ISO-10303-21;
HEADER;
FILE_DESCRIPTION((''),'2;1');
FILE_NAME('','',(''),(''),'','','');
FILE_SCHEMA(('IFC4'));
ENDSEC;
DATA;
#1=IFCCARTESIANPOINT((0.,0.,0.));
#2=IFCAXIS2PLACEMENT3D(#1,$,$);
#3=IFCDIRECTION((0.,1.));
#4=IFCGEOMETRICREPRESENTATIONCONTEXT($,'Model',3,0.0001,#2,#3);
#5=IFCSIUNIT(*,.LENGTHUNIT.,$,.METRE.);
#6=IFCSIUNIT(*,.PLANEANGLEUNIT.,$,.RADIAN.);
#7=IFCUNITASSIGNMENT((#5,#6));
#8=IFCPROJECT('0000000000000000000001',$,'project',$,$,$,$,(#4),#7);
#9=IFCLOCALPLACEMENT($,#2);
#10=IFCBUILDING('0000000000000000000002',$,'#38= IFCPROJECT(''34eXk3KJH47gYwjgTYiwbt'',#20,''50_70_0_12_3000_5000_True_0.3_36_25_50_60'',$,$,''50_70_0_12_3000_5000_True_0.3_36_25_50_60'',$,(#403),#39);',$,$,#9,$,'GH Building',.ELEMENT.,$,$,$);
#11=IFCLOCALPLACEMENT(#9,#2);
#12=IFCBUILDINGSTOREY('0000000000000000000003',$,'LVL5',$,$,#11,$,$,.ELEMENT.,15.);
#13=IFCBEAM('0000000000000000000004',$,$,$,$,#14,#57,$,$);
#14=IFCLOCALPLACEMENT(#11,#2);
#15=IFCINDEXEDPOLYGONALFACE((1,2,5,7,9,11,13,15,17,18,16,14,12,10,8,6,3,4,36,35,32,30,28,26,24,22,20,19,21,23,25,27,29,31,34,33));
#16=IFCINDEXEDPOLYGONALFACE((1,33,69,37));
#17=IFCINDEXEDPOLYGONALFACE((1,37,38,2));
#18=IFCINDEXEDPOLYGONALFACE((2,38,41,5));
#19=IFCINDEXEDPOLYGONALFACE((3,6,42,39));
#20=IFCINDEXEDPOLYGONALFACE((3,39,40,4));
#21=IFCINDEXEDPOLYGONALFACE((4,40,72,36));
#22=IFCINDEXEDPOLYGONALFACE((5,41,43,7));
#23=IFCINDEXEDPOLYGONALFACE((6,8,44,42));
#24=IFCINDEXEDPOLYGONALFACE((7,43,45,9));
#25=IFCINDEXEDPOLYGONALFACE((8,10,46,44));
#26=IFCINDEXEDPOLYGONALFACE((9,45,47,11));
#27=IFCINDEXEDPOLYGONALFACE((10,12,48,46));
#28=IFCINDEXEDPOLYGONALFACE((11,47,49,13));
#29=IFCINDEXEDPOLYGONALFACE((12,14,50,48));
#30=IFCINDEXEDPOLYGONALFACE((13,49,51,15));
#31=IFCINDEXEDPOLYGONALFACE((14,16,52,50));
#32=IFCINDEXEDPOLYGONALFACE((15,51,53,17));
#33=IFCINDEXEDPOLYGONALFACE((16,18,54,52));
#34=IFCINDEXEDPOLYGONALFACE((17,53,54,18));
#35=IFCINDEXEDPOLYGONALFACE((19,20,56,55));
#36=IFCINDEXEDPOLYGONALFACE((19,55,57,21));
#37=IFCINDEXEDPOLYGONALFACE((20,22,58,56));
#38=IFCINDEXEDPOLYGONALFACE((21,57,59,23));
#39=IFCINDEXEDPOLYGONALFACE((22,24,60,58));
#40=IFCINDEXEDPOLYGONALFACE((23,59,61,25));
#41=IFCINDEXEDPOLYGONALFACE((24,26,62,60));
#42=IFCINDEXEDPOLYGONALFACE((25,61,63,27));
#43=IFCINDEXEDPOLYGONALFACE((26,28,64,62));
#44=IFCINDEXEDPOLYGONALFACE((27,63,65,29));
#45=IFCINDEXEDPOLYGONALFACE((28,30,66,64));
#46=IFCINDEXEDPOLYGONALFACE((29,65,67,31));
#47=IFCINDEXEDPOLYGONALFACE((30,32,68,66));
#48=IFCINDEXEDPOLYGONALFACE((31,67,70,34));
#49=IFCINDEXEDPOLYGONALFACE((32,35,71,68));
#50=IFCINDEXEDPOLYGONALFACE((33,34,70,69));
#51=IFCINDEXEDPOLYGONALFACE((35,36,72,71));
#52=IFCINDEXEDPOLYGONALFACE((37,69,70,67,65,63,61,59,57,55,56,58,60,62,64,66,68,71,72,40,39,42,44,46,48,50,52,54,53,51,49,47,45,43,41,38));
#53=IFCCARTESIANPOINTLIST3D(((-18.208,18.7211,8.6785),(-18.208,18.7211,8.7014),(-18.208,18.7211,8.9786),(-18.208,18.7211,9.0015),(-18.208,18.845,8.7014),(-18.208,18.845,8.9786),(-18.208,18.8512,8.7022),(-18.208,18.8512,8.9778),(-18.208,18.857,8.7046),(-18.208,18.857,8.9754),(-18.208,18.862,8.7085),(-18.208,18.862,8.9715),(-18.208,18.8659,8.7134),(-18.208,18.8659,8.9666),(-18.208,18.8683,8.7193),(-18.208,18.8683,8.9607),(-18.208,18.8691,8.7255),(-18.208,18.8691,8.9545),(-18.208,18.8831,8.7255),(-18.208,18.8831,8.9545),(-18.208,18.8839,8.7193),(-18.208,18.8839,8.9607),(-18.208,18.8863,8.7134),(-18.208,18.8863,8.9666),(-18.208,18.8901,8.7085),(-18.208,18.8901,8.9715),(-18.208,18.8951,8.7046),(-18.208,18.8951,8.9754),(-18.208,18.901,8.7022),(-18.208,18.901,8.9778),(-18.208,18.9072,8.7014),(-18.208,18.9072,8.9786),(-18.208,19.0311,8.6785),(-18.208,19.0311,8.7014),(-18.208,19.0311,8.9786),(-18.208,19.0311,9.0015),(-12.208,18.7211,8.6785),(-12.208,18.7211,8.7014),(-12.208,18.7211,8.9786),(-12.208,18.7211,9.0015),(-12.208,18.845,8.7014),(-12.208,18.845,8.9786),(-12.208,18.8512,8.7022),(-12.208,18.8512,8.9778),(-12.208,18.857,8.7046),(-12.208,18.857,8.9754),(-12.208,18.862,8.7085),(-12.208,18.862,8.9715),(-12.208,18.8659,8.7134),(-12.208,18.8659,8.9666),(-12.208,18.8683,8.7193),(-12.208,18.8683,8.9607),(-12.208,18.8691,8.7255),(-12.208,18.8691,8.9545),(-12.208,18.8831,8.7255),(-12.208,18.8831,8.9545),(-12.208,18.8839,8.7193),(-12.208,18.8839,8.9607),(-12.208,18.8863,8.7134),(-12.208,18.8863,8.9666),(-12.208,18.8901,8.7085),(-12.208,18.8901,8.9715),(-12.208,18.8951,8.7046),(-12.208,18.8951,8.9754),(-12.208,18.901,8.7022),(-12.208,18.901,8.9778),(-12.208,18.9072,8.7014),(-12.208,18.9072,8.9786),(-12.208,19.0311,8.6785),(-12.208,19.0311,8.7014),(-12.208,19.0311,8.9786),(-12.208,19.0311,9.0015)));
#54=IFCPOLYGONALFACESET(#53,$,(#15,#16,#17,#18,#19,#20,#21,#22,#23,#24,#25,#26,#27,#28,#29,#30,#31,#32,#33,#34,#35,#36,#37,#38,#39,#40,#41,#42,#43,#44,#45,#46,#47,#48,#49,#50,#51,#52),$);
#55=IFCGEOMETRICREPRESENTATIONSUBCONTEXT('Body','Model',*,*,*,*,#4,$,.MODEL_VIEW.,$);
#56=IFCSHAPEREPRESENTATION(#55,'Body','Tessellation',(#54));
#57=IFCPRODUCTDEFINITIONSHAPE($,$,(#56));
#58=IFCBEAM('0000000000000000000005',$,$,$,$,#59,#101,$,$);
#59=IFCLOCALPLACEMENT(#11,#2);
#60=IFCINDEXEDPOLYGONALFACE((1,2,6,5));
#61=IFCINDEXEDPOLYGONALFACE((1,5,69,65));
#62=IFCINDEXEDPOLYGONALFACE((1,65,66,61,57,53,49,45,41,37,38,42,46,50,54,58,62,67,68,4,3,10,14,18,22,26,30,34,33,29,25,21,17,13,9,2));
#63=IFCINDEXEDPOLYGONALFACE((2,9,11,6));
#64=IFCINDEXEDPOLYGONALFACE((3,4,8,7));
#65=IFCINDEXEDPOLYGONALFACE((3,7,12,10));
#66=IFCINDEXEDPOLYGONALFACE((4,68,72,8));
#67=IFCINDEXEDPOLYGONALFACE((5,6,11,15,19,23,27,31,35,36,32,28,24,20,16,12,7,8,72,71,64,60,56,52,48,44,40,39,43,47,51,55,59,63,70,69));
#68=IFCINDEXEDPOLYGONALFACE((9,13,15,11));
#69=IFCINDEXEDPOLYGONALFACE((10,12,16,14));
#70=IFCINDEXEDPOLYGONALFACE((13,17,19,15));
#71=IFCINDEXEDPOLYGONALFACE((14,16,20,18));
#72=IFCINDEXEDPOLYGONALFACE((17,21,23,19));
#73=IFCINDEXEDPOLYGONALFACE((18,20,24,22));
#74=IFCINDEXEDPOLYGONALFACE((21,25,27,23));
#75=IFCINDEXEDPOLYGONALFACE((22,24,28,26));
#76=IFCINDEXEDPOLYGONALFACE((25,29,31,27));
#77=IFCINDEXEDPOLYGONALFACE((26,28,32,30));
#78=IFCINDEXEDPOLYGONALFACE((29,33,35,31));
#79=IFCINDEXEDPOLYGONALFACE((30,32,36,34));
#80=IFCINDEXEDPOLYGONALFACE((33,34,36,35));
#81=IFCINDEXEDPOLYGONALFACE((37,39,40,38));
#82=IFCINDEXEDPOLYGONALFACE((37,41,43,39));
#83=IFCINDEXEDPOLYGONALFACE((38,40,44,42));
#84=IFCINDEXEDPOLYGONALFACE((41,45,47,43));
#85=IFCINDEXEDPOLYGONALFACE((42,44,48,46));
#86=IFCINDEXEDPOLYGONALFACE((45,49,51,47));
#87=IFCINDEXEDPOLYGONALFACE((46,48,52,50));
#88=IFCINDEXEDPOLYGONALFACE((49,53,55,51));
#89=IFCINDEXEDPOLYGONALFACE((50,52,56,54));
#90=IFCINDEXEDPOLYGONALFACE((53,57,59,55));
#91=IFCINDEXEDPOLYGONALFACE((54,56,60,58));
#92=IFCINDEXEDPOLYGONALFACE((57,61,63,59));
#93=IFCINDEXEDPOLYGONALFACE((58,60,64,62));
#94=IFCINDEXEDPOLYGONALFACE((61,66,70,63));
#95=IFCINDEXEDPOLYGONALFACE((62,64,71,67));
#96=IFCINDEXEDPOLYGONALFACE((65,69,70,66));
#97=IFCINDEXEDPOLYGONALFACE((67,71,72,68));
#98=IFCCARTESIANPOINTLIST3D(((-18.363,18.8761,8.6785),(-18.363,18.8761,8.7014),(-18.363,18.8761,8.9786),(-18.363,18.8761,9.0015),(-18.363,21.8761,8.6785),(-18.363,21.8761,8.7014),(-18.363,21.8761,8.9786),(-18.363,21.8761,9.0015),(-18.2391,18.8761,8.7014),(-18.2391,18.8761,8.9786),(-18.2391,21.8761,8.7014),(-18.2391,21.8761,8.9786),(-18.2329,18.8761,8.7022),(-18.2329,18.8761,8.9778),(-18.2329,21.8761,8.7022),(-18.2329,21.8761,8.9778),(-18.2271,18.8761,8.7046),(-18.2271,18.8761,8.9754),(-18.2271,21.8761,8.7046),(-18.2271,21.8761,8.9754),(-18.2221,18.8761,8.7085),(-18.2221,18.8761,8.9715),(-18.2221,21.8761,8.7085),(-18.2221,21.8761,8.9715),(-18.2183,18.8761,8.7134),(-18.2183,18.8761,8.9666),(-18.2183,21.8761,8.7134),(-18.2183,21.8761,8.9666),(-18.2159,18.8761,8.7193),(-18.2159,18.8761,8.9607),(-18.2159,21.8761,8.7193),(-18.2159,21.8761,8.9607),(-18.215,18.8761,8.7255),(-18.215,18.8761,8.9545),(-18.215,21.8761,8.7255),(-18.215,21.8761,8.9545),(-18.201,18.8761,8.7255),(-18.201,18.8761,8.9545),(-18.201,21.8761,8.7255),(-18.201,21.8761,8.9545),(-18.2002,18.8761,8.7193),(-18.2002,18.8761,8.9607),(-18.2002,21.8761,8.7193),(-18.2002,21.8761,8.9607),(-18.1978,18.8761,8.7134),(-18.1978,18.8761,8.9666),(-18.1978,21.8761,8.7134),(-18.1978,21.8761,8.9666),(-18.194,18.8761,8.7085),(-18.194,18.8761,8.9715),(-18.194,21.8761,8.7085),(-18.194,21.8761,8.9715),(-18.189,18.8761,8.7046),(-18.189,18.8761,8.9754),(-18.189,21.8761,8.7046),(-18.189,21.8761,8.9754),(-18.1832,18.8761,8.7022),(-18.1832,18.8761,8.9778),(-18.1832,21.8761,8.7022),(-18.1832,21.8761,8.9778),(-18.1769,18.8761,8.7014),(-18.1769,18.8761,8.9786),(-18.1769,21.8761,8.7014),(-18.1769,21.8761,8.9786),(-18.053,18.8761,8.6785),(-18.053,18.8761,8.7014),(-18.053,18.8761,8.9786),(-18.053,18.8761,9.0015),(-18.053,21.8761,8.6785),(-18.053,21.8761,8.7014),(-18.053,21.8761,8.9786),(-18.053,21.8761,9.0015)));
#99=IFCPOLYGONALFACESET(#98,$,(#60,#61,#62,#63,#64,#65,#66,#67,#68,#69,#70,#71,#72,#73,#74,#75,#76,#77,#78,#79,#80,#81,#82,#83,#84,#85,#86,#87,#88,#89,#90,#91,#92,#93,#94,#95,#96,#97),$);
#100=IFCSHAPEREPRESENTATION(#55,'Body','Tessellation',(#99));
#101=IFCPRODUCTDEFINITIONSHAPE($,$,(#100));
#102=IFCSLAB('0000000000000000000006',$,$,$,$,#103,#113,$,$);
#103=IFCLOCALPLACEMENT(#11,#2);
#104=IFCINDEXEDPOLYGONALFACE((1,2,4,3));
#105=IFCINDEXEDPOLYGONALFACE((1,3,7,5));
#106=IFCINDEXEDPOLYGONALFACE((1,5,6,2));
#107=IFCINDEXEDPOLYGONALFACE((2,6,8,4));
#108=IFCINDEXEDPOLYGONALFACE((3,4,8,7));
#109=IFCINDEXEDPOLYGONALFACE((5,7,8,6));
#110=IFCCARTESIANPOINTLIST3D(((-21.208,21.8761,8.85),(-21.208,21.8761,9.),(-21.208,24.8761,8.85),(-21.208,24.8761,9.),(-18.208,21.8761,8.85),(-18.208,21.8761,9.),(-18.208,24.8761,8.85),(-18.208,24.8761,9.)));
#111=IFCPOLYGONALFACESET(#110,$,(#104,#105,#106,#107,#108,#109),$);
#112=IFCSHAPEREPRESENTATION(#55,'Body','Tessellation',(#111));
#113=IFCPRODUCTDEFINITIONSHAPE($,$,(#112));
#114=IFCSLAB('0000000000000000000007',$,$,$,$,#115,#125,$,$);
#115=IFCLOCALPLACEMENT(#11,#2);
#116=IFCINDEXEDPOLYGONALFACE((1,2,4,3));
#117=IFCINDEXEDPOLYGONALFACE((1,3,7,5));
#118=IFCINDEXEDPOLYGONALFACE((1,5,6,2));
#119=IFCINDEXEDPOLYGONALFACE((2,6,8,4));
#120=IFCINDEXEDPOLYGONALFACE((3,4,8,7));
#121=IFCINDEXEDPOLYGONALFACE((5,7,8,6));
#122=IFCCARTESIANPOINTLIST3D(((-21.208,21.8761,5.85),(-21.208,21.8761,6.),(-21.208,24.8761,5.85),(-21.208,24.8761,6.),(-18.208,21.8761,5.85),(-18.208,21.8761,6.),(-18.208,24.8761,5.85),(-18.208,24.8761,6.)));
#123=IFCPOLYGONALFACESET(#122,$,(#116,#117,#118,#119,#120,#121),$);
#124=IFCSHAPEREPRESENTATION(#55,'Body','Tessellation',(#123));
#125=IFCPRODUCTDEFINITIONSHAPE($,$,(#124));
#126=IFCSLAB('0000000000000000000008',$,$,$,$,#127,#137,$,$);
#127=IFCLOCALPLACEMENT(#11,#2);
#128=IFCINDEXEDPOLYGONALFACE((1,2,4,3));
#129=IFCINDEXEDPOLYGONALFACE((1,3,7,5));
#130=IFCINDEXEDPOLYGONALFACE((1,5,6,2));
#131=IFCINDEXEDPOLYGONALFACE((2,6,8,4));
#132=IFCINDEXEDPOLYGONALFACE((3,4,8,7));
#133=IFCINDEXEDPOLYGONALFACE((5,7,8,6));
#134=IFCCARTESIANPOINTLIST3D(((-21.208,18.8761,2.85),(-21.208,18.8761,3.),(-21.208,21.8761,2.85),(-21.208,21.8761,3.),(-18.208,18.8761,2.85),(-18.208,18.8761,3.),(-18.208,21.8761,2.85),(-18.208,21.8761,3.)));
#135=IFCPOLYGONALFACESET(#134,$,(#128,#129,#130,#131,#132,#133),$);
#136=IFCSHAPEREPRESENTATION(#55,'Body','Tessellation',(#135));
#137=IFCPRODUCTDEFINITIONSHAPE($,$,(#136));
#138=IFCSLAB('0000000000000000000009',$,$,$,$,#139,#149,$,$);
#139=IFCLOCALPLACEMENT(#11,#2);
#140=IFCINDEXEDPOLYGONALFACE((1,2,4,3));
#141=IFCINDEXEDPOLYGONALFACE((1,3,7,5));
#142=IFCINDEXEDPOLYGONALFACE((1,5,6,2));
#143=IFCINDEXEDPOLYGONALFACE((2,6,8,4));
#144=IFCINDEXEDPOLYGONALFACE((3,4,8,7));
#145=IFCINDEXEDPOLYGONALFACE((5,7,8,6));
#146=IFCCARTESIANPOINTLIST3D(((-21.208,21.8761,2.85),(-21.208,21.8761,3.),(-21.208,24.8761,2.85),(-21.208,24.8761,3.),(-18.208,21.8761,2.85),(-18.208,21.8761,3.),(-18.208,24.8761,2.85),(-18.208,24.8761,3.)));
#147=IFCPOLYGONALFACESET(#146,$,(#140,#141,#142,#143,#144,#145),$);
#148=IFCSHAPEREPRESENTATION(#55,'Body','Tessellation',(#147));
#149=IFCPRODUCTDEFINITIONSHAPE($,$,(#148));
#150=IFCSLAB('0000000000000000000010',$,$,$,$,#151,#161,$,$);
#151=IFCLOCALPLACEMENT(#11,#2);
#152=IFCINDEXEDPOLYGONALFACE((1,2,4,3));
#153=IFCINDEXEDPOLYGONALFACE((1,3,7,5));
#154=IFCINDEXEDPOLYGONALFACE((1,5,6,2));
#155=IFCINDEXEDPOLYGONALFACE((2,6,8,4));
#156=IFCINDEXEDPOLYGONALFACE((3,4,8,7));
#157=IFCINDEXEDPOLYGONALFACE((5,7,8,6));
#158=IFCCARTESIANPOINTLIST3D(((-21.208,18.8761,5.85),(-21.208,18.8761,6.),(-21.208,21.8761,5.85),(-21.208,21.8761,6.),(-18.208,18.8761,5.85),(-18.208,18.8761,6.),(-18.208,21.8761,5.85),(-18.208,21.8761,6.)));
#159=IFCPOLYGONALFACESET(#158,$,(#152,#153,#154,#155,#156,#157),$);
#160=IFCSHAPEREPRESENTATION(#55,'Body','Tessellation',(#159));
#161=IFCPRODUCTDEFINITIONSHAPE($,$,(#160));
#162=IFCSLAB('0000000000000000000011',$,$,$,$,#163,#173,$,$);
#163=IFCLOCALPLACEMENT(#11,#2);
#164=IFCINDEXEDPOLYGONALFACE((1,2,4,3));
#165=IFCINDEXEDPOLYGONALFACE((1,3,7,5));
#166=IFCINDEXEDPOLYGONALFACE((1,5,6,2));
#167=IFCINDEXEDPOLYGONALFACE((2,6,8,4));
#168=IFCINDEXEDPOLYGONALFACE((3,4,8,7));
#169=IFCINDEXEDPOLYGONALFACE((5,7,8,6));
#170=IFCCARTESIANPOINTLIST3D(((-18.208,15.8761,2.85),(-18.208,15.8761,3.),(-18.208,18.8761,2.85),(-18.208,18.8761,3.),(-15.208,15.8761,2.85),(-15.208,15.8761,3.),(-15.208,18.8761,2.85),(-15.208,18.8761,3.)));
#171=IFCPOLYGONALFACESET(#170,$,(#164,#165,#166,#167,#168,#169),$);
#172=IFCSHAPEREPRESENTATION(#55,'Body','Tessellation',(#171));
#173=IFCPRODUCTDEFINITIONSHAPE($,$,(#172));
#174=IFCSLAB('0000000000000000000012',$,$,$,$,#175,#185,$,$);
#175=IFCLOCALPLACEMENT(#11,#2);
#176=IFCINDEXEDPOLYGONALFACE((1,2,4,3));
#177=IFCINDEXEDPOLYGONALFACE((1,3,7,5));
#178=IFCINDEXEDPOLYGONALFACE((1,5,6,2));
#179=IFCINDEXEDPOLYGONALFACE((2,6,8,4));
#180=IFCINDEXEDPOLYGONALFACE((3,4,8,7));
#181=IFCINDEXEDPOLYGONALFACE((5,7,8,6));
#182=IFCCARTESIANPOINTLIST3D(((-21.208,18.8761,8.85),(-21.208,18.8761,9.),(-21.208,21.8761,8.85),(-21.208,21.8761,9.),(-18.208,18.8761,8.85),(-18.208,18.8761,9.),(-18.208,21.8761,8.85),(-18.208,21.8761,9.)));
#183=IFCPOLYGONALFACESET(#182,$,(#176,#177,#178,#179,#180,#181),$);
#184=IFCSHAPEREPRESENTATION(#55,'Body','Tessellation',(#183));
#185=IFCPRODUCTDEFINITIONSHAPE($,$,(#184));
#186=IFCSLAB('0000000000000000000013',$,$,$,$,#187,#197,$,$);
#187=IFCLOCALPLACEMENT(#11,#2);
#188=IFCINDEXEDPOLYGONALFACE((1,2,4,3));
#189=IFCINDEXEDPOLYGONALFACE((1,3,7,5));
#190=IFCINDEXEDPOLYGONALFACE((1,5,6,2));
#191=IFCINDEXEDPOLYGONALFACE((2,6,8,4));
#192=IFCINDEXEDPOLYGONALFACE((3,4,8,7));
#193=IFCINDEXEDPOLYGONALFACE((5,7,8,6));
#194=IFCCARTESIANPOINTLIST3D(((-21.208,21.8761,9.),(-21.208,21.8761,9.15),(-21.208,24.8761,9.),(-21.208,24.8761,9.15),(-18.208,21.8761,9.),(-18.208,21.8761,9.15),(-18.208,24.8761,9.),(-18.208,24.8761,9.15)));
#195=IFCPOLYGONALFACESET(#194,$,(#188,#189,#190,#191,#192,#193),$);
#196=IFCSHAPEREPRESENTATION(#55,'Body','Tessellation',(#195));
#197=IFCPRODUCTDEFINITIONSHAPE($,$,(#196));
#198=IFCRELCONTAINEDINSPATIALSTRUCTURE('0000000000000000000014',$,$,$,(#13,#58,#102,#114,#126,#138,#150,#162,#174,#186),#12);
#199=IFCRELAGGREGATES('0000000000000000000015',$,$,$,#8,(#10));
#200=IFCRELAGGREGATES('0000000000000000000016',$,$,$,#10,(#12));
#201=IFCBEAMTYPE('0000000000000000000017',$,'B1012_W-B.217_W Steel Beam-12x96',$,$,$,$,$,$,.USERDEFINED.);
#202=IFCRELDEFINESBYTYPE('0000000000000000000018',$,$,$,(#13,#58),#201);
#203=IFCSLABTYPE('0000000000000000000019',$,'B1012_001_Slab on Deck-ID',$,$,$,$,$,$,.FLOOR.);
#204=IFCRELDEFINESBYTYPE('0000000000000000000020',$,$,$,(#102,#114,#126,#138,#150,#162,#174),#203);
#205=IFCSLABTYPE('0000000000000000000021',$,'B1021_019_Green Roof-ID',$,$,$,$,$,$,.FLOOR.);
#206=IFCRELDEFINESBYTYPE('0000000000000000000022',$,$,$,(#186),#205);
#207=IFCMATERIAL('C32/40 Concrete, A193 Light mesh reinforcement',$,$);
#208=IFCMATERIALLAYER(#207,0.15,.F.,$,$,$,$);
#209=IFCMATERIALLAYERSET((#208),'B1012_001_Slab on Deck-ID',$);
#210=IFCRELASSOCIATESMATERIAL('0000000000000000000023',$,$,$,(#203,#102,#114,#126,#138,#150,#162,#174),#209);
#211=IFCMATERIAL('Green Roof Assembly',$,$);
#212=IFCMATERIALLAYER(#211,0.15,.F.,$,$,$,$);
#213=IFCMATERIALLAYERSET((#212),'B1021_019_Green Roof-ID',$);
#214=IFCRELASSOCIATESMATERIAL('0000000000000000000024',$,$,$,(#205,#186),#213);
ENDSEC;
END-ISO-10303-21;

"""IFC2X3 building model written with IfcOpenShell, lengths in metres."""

from ifc_helpers import new_model, si_unit, direction, frame, origin, origin_2d, place, context, subcontext, project, spatial, polyline, i_section, outline, extrude, material, layer, layer_set, layer_usage, type_object, element, save


model = new_model("IFC2X3")

# Units and contexts
model_context = context("Model", 3, precision=0.0001, world=origin(), true_north=direction((0.0, 1.0)))
body_context = subcontext(model_context, "Body", "Model", "MODEL_VIEW")
ifc_project = project(units=[si_unit("LENGTHUNIT", "METRE"), si_unit("PLANEANGLEUNIT", "RADIAN")], contexts=[model_context])

# Building, storey
building_placement = place(None, origin())
building = spatial("IfcBuilding", under=ifc_project, at=building_placement, Name="#38= IFCPROJECT('34eXk3KJH47gYwjgTYiwbt',#20,'50_70_0_12_3000_5000_True_0.3_36_25_50_60',$,$,'50_70_0_12_3000_5000_True_0.3_36_25_50_60',$,(#403),#39);", LongName="GH Building", CompositionType="ELEMENT")
storey_placement = place(building_placement, origin())
storey = spatial("IfcBuildingStorey", under=building, at=storey_placement, Name="LVL5", CompositionType="ELEMENT", Elevation=15.0)

# Beams
beam_type = type_object("IfcBeamType", Name="B1012_W-B.217_W Steel Beam-12x96", PredefinedType="USERDEFINED")
beam_1_placement = place(storey_placement, frame((-18.208, 18.8761, 8.84), z_axis=(1.0, 0.0, 0.0), x_axis=(0.0, 1.0, 0.0)))
element("IfcBeam", 1, at=beam_1_placement, inside=storey, type_object=beam_type, context=body_context, shape_type="SweptSolid", body=[
    extrude(i_section(OverallWidth=0.31, OverallDepth=0.323, WebThickness=0.014, FlangeThickness=0.0229, FilletRadius=0.0241, at=origin_2d()), origin(), (0.0, 0.0, 1.0), 6.0),
])
beam_2_placement = place(storey_placement, frame((-18.208, 18.8761, 8.84), z_axis=(0.0, 1.0, 0.0), x_axis=(-1.0, 0.0, 0.0)))
element("IfcBeam", 2, at=beam_2_placement, inside=storey, type_object=beam_type, context=body_context, shape_type="SweptSolid", body=[
    extrude(i_section(OverallWidth=0.31, OverallDepth=0.323, WebThickness=0.014, FlangeThickness=0.0229, FilletRadius=0.0241, at=origin_2d()), origin(), (0.0, 0.0, 1.0), 3.0),
])

# Slabs
ifc_material_1 = material(Name="C32/40 Concrete, A193 Light mesh reinforcement")
ifc_layer_1 = layer(ifc_material_1, 0.15, ventilated=False)
ifc_layer_set_1 = layer_set([ifc_layer_1], Name="B1012_001_Slab on Deck-ID")
ifc_layer_usage_1 = layer_usage(ifc_layer_set_1, "AXIS3", "NEGATIVE", -0.15)
slab_type_1 = type_object("IfcSlabType", Name="B1012_001_Slab on Deck-ID", PredefinedType="FLOOR", material=ifc_layer_set_1)
slab_1_placement = place(storey_placement, frame((-19.708, 23.3761, 8.85), z_axis=(0.0, 0.0, 1.0), x_axis=(0.0, 1.0, 0.0)))
element("IfcSlab", 3, at=slab_1_placement, inside=storey, type_object=slab_type_1, material=ifc_layer_usage_1, context=body_context, shape_type="SweptSolid", body=[
    extrude(outline(polyline([(1.5, -1.5), (1.5, 1.5), (-1.5, 1.5), (-1.5, -1.5), (1.5, -1.5)])), origin(), (0.0, 0.0, 1.0), 0.15),
])
ifc_layer_usage_2 = layer_usage(ifc_layer_set_1, "AXIS3", "NEGATIVE", -0.15)
slab_2_placement = place(storey_placement, frame((-19.708, 23.3761, 5.85), z_axis=(0.0, 0.0, 1.0), x_axis=(0.0, 1.0, 0.0)))
element("IfcSlab", 4, at=slab_2_placement, inside=storey, type_object=slab_type_1, material=ifc_layer_usage_2, context=body_context, shape_type="SweptSolid", body=[
    extrude(outline(polyline([(1.5, -1.5), (1.5, 1.5), (-1.5, 1.5), (-1.5, -1.5), (1.5, -1.5)])), origin(), (0.0, 0.0, 1.0), 0.15),
])
ifc_layer_usage_3 = layer_usage(ifc_layer_set_1, "AXIS3", "NEGATIVE", -0.15)
slab_3_placement = place(storey_placement, frame((-19.708, 20.3761, 2.85)))
element("IfcSlab", 5, at=slab_3_placement, inside=storey, type_object=slab_type_1, material=ifc_layer_usage_3, context=body_context, shape_type="SweptSolid", body=[
    extrude(outline(polyline([(1.5, -1.5), (-1.5, -1.5), (-1.5, 1.5), (1.5, 1.5), (1.5, -1.5)])), origin(), (0.0, 0.0, 1.0), 0.15),
])
ifc_layer_usage_4 = layer_usage(ifc_layer_set_1, "AXIS3", "NEGATIVE", -0.15)
slab_4_placement = place(storey_placement, frame((-19.708, 23.3761, 2.85)))
element("IfcSlab", 6, at=slab_4_placement, inside=storey, type_object=slab_type_1, material=ifc_layer_usage_4, context=body_context, shape_type="SweptSolid", body=[
    extrude(outline(polyline([(1.5, -1.5), (-1.5, -1.5), (-1.5, 1.5), (1.5, 1.5), (1.5, -1.5)])), origin(), (0.0, 0.0, 1.0), 0.15),
])
ifc_layer_usage_5 = layer_usage(ifc_layer_set_1, "AXIS3", "NEGATIVE", -0.15)
slab_5_placement = place(storey_placement, frame((-19.708, 20.3761, 5.85)))
element("IfcSlab", 7, at=slab_5_placement, inside=storey, type_object=slab_type_1, material=ifc_layer_usage_5, context=body_context, shape_type="SweptSolid", body=[
    extrude(outline(polyline([(1.5, -1.5), (-1.5, -1.5), (-1.5, 1.5), (1.5, 1.5), (1.5, -1.5)])), origin(), (0.0, 0.0, 1.0), 0.15),
])
ifc_layer_usage_6 = layer_usage(ifc_layer_set_1, "AXIS3", "NEGATIVE", -0.15)
slab_6_placement = place(storey_placement, frame((-16.708, 17.3761, 2.85)))
element("IfcSlab", 8, at=slab_6_placement, inside=storey, type_object=slab_type_1, material=ifc_layer_usage_6, context=body_context, shape_type="SweptSolid", body=[
    extrude(outline(polyline([(1.5, -1.5), (-1.5, -1.5), (-1.5, 1.5), (1.5, 1.5), (1.5, -1.5)])), origin(), (0.0, 0.0, 1.0), 0.15),
])
ifc_layer_usage_7 = layer_usage(ifc_layer_set_1, "AXIS3", "NEGATIVE", -0.15)
slab_7_placement = place(storey_placement, frame((-19.708, 20.3761, 8.85)))
element("IfcSlab", 9, at=slab_7_placement, inside=storey, type_object=slab_type_1, material=ifc_layer_usage_7, context=body_context, shape_type="SweptSolid", body=[
    extrude(outline(polyline([(1.5, -1.5), (-1.5, -1.5), (-1.5, 1.5), (1.5, 1.5), (1.5, -1.5)])), origin(), (0.0, 0.0, 1.0), 0.15),
])
ifc_material_2 = material(Name="Green Roof Assembly")
ifc_layer_2 = layer(ifc_material_2, 0.15, ventilated=False)
ifc_layer_set_2 = layer_set([ifc_layer_2], Name="B1021_019_Green Roof-ID")
ifc_layer_usage_8 = layer_usage(ifc_layer_set_2, "AXIS3", "NEGATIVE", -0.15)
slab_type_2 = type_object("IfcSlabType", Name="B1021_019_Green Roof-ID", PredefinedType="FLOOR", material=ifc_layer_set_2)
slab_8_placement = place(storey_placement, frame((-19.708, 23.3761, 9.0), z_axis=(0.0, 0.0, 1.0), x_axis=(0.0, 1.0, 0.0)))
element("IfcSlab", 10, at=slab_8_placement, inside=storey, type_object=slab_type_2, material=ifc_layer_usage_8, context=body_context, shape_type="SweptSolid", body=[
    extrude(outline(polyline([(1.5, -1.5), (1.5, 1.5), (-1.5, 1.5), (-1.5, -1.5), (1.5, -1.5)])), origin(), (0.0, 0.0, 1.0), 0.15),
])

save(model, "model.ifc")
